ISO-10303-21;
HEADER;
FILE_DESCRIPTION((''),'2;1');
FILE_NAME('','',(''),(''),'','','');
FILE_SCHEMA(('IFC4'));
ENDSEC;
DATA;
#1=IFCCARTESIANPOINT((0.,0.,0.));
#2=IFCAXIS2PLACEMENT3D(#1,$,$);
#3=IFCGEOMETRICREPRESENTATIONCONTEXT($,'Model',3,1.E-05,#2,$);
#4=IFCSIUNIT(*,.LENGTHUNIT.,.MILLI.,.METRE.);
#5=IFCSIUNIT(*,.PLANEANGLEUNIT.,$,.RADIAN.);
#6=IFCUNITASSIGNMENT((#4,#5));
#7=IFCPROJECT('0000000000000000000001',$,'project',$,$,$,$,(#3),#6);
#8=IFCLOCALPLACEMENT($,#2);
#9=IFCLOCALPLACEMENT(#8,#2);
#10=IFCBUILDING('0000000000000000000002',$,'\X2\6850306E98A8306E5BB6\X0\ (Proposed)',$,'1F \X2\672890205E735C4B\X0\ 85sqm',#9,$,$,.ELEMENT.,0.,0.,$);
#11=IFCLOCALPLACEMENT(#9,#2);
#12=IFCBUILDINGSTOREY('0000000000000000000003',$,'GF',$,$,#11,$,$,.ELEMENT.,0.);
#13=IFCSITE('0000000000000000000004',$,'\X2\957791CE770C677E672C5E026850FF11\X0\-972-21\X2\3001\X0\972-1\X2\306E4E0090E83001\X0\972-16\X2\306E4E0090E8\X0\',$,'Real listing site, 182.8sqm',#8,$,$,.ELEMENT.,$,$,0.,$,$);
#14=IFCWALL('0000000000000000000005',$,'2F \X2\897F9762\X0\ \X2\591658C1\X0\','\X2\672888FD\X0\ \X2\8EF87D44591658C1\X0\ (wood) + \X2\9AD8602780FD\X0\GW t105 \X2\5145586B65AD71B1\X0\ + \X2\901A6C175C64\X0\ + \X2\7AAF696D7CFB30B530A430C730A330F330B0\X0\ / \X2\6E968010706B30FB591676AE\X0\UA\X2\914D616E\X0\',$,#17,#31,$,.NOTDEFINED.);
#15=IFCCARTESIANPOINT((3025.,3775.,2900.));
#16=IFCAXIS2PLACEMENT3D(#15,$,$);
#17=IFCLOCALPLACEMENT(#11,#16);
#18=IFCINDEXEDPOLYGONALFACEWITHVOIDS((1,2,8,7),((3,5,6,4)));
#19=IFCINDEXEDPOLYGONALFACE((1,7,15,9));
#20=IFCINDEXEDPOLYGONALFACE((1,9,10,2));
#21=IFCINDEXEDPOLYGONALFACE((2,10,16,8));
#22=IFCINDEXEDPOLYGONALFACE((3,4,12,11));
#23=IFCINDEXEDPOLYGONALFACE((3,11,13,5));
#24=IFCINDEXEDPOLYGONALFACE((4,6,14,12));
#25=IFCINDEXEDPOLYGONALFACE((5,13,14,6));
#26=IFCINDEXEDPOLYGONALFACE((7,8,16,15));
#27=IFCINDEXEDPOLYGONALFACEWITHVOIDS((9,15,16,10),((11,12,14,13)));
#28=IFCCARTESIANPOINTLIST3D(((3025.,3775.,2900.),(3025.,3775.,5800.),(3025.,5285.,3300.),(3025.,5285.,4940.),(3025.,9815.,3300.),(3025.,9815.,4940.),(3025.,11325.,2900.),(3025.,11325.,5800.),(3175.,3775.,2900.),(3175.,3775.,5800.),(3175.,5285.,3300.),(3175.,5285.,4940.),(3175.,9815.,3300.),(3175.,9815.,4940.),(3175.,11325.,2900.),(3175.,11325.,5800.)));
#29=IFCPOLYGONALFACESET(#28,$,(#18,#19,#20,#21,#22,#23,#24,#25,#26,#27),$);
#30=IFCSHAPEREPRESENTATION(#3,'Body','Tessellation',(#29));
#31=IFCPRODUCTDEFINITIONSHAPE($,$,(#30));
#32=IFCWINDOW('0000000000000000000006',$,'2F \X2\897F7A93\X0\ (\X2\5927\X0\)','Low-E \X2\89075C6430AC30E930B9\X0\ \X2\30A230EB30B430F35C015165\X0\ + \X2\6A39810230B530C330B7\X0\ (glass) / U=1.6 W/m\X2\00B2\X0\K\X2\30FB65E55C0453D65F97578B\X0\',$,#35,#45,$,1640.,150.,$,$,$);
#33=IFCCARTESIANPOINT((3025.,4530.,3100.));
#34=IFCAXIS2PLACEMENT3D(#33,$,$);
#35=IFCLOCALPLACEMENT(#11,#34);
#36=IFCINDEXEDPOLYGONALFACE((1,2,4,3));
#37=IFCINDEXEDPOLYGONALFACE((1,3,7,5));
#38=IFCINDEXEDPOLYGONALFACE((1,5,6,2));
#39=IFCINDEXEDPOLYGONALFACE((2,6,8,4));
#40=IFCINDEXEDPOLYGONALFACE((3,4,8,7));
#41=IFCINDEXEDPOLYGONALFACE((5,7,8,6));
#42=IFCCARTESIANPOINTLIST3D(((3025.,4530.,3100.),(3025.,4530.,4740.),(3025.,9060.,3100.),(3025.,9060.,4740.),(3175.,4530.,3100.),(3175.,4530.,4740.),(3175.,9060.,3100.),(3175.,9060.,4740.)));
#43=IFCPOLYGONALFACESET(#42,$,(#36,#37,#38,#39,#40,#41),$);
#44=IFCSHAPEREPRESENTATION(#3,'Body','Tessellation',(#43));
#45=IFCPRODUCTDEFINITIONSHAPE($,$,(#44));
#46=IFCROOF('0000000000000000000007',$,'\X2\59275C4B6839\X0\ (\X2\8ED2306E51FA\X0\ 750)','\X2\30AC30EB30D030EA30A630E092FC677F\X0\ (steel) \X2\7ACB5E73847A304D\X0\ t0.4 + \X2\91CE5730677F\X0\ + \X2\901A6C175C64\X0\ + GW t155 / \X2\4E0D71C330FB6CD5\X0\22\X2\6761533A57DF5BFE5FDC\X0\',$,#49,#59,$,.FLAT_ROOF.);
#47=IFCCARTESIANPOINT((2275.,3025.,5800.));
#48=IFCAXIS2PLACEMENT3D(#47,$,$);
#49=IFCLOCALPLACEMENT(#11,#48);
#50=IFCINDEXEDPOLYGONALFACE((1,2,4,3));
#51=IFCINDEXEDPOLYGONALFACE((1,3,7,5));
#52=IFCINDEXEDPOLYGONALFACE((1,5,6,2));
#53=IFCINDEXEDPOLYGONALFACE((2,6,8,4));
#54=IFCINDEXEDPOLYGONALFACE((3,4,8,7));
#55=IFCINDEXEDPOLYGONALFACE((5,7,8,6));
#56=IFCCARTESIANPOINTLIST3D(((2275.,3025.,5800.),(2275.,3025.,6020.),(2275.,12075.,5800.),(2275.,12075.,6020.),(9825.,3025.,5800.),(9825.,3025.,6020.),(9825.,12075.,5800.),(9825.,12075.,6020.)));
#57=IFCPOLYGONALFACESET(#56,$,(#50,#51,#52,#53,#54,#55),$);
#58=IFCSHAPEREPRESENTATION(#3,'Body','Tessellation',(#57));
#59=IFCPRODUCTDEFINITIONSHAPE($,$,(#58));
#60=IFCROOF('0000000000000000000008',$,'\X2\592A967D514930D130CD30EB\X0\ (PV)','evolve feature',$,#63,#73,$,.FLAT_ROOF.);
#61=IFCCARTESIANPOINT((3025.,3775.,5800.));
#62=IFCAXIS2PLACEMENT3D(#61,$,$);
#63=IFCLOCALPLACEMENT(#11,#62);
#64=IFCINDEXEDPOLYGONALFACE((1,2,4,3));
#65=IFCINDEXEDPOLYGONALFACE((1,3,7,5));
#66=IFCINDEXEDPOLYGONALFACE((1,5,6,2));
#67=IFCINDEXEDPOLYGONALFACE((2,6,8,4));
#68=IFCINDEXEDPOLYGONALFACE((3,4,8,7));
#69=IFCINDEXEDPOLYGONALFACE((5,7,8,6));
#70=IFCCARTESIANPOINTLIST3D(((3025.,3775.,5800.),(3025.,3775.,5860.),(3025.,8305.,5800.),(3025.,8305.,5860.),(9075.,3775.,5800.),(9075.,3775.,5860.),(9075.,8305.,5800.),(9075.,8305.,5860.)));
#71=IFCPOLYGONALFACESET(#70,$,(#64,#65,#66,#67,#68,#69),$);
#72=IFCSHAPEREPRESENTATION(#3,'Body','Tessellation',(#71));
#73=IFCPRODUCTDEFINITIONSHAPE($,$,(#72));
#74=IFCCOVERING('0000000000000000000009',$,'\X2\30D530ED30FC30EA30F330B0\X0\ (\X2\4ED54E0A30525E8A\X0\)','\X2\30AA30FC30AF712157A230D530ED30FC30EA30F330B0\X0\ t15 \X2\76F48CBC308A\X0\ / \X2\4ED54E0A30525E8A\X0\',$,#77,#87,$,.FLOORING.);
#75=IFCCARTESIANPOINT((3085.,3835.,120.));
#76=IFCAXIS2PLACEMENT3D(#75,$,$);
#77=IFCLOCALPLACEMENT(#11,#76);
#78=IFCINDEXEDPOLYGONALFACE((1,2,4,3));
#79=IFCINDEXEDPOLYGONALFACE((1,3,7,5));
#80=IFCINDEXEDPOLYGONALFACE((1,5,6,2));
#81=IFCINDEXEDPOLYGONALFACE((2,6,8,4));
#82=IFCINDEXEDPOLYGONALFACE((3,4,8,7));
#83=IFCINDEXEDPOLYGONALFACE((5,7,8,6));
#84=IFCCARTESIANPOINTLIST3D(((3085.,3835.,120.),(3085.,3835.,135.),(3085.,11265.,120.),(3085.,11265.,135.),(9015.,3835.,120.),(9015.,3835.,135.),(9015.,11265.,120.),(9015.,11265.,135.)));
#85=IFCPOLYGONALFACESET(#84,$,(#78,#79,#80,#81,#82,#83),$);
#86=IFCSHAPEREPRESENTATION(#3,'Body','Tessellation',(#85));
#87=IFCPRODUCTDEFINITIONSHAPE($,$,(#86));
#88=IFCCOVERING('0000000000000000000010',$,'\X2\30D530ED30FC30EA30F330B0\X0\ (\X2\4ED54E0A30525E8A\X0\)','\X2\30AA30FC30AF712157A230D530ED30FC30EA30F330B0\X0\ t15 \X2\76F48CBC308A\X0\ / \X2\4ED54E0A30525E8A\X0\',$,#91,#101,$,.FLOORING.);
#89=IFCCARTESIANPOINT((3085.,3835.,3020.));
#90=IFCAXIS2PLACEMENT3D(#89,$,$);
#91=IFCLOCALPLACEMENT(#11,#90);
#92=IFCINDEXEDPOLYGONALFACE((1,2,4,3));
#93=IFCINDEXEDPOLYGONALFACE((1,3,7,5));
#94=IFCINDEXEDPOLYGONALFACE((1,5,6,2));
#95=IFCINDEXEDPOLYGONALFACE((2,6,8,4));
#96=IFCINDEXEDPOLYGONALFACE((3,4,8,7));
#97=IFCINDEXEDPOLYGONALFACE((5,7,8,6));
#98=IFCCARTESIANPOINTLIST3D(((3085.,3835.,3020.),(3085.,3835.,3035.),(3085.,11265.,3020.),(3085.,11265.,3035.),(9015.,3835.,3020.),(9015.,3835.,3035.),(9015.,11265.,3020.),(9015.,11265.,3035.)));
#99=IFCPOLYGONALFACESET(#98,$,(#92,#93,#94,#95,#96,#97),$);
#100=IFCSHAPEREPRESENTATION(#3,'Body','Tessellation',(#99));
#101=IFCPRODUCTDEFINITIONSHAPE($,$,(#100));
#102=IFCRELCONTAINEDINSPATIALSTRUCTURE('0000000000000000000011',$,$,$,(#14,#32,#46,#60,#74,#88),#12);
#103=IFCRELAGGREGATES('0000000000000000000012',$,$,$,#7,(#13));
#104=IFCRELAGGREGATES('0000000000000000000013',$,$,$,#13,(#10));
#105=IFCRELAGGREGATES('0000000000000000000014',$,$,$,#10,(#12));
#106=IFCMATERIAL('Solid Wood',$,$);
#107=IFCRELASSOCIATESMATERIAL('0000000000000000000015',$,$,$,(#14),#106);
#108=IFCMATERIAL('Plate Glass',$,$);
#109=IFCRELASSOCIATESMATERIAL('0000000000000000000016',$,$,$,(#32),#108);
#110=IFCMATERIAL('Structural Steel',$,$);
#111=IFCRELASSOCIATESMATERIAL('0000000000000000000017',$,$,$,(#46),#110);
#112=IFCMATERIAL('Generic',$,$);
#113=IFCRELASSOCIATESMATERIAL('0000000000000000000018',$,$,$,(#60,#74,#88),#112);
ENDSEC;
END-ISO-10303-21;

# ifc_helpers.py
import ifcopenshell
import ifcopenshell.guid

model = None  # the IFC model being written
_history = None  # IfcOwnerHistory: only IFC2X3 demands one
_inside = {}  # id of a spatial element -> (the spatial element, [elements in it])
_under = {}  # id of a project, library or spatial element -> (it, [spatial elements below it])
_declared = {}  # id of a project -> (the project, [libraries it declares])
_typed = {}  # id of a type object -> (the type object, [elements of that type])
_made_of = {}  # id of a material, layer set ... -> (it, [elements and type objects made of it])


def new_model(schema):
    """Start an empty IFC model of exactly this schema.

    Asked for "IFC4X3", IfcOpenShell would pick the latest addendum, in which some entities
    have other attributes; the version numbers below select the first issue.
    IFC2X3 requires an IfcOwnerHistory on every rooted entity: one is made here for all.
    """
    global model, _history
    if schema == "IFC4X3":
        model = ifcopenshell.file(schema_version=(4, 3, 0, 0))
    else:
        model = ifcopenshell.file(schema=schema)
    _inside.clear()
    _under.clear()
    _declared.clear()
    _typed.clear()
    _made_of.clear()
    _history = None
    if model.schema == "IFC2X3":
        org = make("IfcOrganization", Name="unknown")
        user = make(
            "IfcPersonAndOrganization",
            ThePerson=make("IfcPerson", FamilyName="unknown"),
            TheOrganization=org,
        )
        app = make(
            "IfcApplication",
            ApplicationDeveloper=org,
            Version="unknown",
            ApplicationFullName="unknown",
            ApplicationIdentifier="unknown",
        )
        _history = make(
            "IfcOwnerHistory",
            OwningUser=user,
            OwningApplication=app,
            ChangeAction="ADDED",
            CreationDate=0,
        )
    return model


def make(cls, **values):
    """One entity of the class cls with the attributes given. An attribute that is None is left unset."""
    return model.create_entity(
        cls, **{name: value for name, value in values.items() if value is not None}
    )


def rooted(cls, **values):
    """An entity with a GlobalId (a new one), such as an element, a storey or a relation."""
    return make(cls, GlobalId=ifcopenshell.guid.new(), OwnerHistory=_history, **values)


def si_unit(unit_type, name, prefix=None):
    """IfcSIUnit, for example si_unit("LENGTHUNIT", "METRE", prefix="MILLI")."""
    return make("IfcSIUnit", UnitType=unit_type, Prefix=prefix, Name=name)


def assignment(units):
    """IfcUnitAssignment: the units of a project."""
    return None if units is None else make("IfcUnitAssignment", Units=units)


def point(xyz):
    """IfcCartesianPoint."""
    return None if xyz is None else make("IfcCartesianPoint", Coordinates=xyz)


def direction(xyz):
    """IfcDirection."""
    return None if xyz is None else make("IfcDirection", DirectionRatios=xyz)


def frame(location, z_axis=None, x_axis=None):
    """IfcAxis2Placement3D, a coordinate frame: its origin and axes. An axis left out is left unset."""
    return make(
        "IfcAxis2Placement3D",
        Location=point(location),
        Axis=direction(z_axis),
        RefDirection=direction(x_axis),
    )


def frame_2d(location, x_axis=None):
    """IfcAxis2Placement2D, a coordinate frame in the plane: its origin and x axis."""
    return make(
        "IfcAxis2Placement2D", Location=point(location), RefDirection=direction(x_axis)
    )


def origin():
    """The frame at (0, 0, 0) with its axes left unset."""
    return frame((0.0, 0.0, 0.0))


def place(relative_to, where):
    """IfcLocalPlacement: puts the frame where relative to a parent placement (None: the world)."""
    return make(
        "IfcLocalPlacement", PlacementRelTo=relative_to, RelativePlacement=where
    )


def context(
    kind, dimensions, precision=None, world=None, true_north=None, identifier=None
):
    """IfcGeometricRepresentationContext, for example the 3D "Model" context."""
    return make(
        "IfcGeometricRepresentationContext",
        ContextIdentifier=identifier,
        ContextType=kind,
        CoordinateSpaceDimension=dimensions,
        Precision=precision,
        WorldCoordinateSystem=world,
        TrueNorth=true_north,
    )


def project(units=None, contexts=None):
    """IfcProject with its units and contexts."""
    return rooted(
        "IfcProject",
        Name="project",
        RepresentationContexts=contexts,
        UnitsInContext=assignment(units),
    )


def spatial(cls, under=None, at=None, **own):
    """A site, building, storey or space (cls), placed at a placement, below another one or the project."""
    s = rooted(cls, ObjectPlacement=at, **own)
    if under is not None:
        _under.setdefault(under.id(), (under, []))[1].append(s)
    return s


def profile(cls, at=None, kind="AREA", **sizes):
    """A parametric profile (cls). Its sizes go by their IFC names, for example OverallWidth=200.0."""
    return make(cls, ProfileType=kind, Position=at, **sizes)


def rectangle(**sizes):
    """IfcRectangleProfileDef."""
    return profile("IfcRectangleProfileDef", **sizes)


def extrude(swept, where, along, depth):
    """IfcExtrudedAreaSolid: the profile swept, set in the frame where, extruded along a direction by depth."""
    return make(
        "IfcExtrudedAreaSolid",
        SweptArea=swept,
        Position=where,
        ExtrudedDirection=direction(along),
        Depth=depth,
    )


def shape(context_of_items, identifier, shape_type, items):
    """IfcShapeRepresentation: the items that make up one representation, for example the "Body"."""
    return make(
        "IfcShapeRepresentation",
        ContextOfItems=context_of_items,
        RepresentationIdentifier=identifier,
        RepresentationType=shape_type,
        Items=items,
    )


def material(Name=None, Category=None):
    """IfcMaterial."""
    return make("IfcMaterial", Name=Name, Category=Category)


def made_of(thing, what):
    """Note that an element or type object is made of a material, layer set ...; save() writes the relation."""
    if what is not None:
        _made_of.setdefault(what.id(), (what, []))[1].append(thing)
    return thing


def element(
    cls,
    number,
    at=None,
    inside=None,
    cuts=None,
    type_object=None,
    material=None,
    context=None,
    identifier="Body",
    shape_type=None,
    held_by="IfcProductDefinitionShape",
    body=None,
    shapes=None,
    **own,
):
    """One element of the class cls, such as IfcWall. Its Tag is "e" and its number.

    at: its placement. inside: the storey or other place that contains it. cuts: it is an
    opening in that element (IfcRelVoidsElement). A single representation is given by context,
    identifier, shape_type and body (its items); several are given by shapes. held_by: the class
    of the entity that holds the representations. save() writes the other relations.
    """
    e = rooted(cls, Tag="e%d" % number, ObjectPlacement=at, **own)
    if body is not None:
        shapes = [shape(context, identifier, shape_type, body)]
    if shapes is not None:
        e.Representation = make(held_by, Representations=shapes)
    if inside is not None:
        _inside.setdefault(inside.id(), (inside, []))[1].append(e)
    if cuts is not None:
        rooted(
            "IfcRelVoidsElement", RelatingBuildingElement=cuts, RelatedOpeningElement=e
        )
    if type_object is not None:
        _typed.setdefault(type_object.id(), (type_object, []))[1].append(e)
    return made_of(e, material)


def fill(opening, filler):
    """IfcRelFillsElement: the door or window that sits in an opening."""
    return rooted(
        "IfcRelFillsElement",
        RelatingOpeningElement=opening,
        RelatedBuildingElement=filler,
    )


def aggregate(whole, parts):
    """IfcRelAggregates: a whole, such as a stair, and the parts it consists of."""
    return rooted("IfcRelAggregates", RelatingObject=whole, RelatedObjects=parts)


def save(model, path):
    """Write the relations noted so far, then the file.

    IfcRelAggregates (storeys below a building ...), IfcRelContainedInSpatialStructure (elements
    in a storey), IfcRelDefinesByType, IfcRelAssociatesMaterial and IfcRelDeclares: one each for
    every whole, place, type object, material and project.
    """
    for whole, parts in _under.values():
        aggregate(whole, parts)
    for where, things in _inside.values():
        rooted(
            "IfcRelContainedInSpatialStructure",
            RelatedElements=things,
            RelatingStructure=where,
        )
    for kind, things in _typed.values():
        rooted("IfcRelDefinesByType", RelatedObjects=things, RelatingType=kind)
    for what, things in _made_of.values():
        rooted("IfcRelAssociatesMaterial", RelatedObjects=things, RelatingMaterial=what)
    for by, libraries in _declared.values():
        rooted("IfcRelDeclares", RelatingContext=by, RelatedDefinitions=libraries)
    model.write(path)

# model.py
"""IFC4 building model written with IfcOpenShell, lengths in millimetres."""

from ifc_helpers import new_model, si_unit, frame, frame_2d, origin, place, context, project, spatial, rectangle, extrude, material, element, fill, save


model = new_model("IFC4")

# Units and contexts
model_context = context("Model", 3, precision=1e-05, world=origin())
ifc_project = project(units=[si_unit("LENGTHUNIT", "METRE", prefix="MILLI"), si_unit("PLANEANGLEUNIT", "RADIAN")], contexts=[model_context])

# Site, building, storey
site_placement = place(None, origin())
site = spatial("IfcSite", under=ifc_project, at=site_placement, Name="長野県松本市桐１-972-21、972-1の一部、972-16の一部", ObjectType="Real listing site, 182.8sqm", CompositionType="ELEMENT", RefElevation=0.0)
building_placement = place(site_placement, origin())
building = spatial("IfcBuilding", under=site, at=building_placement, Name="桐の風の家 (Proposed)", ObjectType="1F 木造平屋 85sqm", CompositionType="ELEMENT", ElevationOfRefHeight=0.0, ElevationOfTerrain=0.0)
storey_placement = place(building_placement, origin())
storey = spatial("IfcBuildingStorey", under=building, at=storey_placement, Name="GF", CompositionType="ELEMENT", Elevation=0.0)

# Shared definitions
ifc_material_1 = material(Name="Solid Wood")
ifc_material_2 = material(Name="Generic")

# Shared definitions
ifc_material_3 = material(Name="Plate Glass")

# Wall, opening, window
wall_1_placement = place(storey_placement, frame((3025.0, 3775.0, 2900.0)))
wall_1 = element("IfcWall", 1, at=wall_1_placement, inside=storey, material=ifc_material_1, Name="2F 西面 外壁", Description="木製 軸組外壁 (wood) + 高性能GW t105 充填断熱 + 通気層 + 窯業系サイディング / 準耐火・外皮UA配慮", PredefinedType="NOTDEFINED", context=model_context, shape_type="SweptSolid", body=[
    extrude(rectangle(XDim=150.0, YDim=7550.0, at=frame_2d((75.0, 3775.0))), frame((3025.0, 3775.0, 2900.0)), (0.0, 0.0, 1.0), 2900.0),
])
opening_1_placement = place(storey_placement, frame((3025.0, 4530.0, 3100.0)))
opening_1 = element("IfcOpeningElement", 2, at=opening_1_placement, cuts=wall_1, PredefinedType="NOTDEFINED", context=model_context, shape_type="SweptSolid", body=[
    extrude(rectangle(XDim=150.0, YDim=4530.0, at=frame_2d((75.0, 2265.0))), frame((3025.0, 4530.0, 3100.0)), (0.0, 0.0, 1.0), 1640.0),
])
window_1_placement = place(storey_placement, frame((3025.0, 4530.0, 3100.0)))
window_1 = element("IfcWindow", 3, at=window_1_placement, inside=storey, material=ifc_material_3, Name="2F 西窓 (大)", Description="Low-E 複層ガラス アルゴン封入 + 樹脂サッシ (glass) / U=1.6 W/m²K・日射取得型", OverallHeight=1640.0, OverallWidth=150.0, context=model_context, shape_type="SweptSolid", body=[
    extrude(rectangle(XDim=150.0, YDim=4530.0, at=frame_2d((75.0, 2265.0))), frame((3025.0, 4530.0, 3100.0)), (0.0, 0.0, 1.0), 1640.0),
])
fill(opening_1, window_1)

# Roofs
ifc_material_4 = material(Name="Structural Steel")
roof_1_placement = place(storey_placement, frame((2275.0, 3025.0, 5800.0)))
element("IfcRoof", 4, at=roof_1_placement, inside=storey, material=ifc_material_4, Name="大屋根 (軒の出 750)", Description="ガルバリウム鋼板 (steel) 立平葺き t0.4 + 野地板 + 通気層 + GW t155 / 不燃・法22条区域対応", PredefinedType="FLAT_ROOF", context=model_context, shape_type="SweptSolid", body=[
    extrude(rectangle(XDim=7550.0, YDim=9050.0, at=frame_2d((3775.0, 4525.0))), frame((2275.0, 3025.0, 5800.0)), (0.0, 0.0, 1.0), 220.0),
])
roof_2_placement = place(storey_placement, frame((3025.0, 3775.0, 5800.0)))
element("IfcRoof", 5, at=roof_2_placement, inside=storey, material=ifc_material_2, Name="太陽光パネル (PV)", Description="evolve feature", PredefinedType="FLAT_ROOF", context=model_context, shape_type="SweptSolid", body=[
    extrude(rectangle(XDim=6050.0, YDim=4530.0, at=frame_2d((3025.0, 2265.0))), frame((3025.0, 3775.0, 5800.0)), (0.0, 0.0, 1.0), 60.0),
])

# Coverings
covering_1_placement = place(storey_placement, frame((3085.0, 3835.0, 120.0)))
element("IfcCovering", 6, at=covering_1_placement, inside=storey, material=ifc_material_2, Name="フローリング (仕上げ床)", Description="オーク無垢フローリング t15 直貼り / 仕上げ床", PredefinedType="FLOORING", context=model_context, shape_type="SweptSolid", body=[
    extrude(rectangle(XDim=5930.0, YDim=7430.0, at=frame_2d((2965.0, 3715.0))), frame((3085.0, 3835.0, 120.0)), (0.0, 0.0, 1.0), 15.0),
])
covering_2_placement = place(storey_placement, frame((3085.0, 3835.0, 3020.0)))
element("IfcCovering", 7, at=covering_2_placement, inside=storey, material=ifc_material_2, Name="フローリング (仕上げ床)", Description="オーク無垢フローリング t15 直貼り / 仕上げ床", PredefinedType="FLOORING", context=model_context, shape_type="SweptSolid", body=[
    extrude(rectangle(XDim=5930.0, YDim=7430.0, at=frame_2d((2965.0, 3715.0))), frame((3085.0, 3835.0, 3020.0)), (0.0, 0.0, 1.0), 15.0),
])

save(model, "model.ifc")
